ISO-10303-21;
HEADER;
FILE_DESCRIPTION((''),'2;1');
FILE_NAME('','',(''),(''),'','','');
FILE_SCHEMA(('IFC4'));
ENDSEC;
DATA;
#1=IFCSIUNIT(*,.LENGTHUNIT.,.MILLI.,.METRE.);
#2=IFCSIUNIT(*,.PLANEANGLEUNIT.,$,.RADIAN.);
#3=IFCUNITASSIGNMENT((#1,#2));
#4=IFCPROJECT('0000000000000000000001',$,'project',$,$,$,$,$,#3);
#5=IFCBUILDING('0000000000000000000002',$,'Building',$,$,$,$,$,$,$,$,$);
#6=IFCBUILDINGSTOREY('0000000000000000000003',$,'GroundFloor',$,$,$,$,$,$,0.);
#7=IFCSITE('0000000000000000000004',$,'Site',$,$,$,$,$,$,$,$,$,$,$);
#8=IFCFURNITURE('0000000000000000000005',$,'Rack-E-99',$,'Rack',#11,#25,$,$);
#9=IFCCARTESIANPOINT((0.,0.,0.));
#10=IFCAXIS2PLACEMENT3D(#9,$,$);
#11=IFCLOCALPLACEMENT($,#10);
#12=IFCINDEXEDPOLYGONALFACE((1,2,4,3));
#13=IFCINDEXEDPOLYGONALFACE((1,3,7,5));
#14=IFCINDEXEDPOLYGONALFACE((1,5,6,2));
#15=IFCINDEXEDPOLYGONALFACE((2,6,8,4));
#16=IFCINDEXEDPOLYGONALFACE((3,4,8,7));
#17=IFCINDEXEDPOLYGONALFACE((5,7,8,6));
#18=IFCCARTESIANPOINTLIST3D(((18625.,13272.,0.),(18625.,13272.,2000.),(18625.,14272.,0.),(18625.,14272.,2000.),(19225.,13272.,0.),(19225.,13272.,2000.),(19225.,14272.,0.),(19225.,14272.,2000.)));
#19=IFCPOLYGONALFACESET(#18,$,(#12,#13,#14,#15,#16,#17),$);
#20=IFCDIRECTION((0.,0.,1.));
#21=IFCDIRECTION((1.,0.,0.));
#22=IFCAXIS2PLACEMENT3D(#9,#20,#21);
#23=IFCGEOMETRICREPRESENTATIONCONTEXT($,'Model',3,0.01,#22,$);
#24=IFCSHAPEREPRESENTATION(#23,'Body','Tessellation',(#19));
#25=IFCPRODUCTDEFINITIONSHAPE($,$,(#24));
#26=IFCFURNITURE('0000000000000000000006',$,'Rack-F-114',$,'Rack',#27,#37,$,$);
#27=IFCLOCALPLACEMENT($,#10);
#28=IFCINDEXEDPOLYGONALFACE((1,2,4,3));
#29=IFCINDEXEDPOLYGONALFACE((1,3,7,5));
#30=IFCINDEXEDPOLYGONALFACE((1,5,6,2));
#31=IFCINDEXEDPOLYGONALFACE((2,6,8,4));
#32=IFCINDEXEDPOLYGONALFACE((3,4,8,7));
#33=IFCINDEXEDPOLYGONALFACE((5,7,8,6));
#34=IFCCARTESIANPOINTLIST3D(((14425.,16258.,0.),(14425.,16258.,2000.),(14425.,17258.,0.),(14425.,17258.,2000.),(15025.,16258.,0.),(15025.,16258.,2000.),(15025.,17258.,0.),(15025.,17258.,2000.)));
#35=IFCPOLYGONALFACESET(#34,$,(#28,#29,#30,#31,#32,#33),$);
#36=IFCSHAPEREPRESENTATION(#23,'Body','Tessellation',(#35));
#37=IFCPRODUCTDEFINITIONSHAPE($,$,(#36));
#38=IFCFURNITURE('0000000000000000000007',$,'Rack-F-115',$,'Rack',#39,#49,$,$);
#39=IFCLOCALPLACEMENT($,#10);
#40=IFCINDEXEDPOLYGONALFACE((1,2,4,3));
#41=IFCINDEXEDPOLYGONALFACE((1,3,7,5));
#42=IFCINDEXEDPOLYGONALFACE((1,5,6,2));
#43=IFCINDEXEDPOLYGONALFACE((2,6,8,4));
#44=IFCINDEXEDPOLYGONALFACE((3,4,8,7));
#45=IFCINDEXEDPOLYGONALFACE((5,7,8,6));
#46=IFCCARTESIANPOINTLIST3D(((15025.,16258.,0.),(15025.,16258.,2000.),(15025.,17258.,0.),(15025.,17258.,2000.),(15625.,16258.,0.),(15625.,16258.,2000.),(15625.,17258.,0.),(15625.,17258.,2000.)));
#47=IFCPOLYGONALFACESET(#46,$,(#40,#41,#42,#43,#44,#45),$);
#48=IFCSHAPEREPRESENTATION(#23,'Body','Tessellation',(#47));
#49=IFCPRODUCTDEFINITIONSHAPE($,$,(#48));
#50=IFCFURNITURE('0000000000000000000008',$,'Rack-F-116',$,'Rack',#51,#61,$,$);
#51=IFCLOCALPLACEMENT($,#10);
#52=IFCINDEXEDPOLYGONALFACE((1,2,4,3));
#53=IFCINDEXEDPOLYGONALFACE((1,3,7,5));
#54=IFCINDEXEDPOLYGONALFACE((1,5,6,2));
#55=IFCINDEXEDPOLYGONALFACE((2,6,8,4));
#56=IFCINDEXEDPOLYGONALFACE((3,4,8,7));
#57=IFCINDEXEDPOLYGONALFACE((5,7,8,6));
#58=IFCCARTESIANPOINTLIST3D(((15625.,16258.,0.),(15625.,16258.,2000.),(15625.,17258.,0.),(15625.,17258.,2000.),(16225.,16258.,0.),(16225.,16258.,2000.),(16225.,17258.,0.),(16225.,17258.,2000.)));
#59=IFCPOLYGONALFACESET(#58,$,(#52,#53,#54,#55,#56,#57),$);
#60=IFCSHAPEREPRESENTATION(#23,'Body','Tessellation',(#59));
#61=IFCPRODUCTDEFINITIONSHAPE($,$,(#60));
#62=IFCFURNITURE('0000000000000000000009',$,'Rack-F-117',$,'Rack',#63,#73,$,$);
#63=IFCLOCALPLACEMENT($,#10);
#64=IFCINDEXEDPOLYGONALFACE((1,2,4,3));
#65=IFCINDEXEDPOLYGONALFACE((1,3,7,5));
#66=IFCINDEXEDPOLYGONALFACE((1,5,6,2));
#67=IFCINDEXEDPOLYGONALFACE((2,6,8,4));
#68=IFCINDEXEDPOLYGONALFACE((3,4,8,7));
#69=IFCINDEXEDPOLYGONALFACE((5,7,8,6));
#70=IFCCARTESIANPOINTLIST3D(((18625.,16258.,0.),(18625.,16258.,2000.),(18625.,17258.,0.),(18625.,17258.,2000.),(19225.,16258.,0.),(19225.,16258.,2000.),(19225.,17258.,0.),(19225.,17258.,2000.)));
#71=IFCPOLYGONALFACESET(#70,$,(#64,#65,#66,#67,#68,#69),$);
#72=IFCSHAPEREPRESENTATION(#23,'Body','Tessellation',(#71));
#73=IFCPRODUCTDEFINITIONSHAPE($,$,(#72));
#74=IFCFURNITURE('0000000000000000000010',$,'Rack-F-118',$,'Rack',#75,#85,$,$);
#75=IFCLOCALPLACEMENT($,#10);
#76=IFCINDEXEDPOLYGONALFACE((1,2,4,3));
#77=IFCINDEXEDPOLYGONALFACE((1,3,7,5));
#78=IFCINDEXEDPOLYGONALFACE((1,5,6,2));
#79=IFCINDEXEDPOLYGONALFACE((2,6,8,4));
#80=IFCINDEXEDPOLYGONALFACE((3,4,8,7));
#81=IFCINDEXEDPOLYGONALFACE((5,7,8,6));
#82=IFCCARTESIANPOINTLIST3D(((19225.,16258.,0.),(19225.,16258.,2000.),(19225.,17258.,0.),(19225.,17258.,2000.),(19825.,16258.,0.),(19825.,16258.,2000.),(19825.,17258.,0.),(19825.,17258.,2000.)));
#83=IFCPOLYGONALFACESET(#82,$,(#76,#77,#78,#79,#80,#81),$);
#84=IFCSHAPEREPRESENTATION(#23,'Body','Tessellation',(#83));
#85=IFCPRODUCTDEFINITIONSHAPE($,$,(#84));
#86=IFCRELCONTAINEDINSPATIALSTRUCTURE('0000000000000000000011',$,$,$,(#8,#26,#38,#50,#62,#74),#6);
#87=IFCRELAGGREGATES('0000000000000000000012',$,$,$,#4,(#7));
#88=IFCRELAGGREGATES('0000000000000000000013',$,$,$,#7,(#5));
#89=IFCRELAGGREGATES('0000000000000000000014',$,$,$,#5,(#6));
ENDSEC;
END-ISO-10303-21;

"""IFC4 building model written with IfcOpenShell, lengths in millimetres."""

from ifc_helpers import new_model, si_unit, frame, origin, origin_with_axes, origin_2d, place, context, project, spatial, rectangle, extrude, element, save


model = new_model("IFC4")

# Units and contexts
model_context = context("Model", 3, precision=0.01, world=origin_with_axes())
ifc_project = project(units=[si_unit("LENGTHUNIT", "METRE", prefix="MILLI"), si_unit("PLANEANGLEUNIT", "RADIAN")])

# Site, building, storey
site = spatial("IfcSite", under=ifc_project, Name="Site")
building = spatial("IfcBuilding", under=site, Name="Building")
storey = spatial("IfcBuildingStorey", under=building, Name="GroundFloor", Elevation=0.0)

# Furniture
for number, where, z_axis, x_axis, name in (
    (1, (18925.0, 13772.0, 0.0), (0.0, 0.0, 1.0), (1.0, 0.0, 0.0), "Rack-E-99"),
    (2, (14725.0, 16758.0, 0.0), (0.0, 0.0, 1.0), (1.0, 0.0, 0.0), "Rack-F-114"),
    (3, (15325.0, 16758.0, 0.0), (0.0, 0.0, 1.0), (1.0, 0.0, 0.0), "Rack-F-115"),
    (4, (15925.0, 16758.0, 0.0), (0.0, 0.0, 1.0), (1.0, 0.0, 0.0), "Rack-F-116"),
    (5, (18925.0, 16758.0, 0.0), (0.0, 0.0, 1.0), (1.0, 0.0, 0.0), "Rack-F-117"),
    (6, (19525.0, 16758.0, 0.0), (0.0, 0.0, 1.0), (1.0, 0.0, 0.0), "Rack-F-118"),
):
    element("IfcFurniture", number, at=place(None, frame(where, z_axis=z_axis, x_axis=x_axis)), inside=storey, Name=name, ObjectType="Rack", context=model_context, shape_type="SweptSolid", body=[
        extrude(rectangle(XDim=600.0, YDim=1000.0, at=origin_2d()), origin(), (0.0, 0.0, 1.0), 2000.0),
    ])

save(model, "model.ifc")
